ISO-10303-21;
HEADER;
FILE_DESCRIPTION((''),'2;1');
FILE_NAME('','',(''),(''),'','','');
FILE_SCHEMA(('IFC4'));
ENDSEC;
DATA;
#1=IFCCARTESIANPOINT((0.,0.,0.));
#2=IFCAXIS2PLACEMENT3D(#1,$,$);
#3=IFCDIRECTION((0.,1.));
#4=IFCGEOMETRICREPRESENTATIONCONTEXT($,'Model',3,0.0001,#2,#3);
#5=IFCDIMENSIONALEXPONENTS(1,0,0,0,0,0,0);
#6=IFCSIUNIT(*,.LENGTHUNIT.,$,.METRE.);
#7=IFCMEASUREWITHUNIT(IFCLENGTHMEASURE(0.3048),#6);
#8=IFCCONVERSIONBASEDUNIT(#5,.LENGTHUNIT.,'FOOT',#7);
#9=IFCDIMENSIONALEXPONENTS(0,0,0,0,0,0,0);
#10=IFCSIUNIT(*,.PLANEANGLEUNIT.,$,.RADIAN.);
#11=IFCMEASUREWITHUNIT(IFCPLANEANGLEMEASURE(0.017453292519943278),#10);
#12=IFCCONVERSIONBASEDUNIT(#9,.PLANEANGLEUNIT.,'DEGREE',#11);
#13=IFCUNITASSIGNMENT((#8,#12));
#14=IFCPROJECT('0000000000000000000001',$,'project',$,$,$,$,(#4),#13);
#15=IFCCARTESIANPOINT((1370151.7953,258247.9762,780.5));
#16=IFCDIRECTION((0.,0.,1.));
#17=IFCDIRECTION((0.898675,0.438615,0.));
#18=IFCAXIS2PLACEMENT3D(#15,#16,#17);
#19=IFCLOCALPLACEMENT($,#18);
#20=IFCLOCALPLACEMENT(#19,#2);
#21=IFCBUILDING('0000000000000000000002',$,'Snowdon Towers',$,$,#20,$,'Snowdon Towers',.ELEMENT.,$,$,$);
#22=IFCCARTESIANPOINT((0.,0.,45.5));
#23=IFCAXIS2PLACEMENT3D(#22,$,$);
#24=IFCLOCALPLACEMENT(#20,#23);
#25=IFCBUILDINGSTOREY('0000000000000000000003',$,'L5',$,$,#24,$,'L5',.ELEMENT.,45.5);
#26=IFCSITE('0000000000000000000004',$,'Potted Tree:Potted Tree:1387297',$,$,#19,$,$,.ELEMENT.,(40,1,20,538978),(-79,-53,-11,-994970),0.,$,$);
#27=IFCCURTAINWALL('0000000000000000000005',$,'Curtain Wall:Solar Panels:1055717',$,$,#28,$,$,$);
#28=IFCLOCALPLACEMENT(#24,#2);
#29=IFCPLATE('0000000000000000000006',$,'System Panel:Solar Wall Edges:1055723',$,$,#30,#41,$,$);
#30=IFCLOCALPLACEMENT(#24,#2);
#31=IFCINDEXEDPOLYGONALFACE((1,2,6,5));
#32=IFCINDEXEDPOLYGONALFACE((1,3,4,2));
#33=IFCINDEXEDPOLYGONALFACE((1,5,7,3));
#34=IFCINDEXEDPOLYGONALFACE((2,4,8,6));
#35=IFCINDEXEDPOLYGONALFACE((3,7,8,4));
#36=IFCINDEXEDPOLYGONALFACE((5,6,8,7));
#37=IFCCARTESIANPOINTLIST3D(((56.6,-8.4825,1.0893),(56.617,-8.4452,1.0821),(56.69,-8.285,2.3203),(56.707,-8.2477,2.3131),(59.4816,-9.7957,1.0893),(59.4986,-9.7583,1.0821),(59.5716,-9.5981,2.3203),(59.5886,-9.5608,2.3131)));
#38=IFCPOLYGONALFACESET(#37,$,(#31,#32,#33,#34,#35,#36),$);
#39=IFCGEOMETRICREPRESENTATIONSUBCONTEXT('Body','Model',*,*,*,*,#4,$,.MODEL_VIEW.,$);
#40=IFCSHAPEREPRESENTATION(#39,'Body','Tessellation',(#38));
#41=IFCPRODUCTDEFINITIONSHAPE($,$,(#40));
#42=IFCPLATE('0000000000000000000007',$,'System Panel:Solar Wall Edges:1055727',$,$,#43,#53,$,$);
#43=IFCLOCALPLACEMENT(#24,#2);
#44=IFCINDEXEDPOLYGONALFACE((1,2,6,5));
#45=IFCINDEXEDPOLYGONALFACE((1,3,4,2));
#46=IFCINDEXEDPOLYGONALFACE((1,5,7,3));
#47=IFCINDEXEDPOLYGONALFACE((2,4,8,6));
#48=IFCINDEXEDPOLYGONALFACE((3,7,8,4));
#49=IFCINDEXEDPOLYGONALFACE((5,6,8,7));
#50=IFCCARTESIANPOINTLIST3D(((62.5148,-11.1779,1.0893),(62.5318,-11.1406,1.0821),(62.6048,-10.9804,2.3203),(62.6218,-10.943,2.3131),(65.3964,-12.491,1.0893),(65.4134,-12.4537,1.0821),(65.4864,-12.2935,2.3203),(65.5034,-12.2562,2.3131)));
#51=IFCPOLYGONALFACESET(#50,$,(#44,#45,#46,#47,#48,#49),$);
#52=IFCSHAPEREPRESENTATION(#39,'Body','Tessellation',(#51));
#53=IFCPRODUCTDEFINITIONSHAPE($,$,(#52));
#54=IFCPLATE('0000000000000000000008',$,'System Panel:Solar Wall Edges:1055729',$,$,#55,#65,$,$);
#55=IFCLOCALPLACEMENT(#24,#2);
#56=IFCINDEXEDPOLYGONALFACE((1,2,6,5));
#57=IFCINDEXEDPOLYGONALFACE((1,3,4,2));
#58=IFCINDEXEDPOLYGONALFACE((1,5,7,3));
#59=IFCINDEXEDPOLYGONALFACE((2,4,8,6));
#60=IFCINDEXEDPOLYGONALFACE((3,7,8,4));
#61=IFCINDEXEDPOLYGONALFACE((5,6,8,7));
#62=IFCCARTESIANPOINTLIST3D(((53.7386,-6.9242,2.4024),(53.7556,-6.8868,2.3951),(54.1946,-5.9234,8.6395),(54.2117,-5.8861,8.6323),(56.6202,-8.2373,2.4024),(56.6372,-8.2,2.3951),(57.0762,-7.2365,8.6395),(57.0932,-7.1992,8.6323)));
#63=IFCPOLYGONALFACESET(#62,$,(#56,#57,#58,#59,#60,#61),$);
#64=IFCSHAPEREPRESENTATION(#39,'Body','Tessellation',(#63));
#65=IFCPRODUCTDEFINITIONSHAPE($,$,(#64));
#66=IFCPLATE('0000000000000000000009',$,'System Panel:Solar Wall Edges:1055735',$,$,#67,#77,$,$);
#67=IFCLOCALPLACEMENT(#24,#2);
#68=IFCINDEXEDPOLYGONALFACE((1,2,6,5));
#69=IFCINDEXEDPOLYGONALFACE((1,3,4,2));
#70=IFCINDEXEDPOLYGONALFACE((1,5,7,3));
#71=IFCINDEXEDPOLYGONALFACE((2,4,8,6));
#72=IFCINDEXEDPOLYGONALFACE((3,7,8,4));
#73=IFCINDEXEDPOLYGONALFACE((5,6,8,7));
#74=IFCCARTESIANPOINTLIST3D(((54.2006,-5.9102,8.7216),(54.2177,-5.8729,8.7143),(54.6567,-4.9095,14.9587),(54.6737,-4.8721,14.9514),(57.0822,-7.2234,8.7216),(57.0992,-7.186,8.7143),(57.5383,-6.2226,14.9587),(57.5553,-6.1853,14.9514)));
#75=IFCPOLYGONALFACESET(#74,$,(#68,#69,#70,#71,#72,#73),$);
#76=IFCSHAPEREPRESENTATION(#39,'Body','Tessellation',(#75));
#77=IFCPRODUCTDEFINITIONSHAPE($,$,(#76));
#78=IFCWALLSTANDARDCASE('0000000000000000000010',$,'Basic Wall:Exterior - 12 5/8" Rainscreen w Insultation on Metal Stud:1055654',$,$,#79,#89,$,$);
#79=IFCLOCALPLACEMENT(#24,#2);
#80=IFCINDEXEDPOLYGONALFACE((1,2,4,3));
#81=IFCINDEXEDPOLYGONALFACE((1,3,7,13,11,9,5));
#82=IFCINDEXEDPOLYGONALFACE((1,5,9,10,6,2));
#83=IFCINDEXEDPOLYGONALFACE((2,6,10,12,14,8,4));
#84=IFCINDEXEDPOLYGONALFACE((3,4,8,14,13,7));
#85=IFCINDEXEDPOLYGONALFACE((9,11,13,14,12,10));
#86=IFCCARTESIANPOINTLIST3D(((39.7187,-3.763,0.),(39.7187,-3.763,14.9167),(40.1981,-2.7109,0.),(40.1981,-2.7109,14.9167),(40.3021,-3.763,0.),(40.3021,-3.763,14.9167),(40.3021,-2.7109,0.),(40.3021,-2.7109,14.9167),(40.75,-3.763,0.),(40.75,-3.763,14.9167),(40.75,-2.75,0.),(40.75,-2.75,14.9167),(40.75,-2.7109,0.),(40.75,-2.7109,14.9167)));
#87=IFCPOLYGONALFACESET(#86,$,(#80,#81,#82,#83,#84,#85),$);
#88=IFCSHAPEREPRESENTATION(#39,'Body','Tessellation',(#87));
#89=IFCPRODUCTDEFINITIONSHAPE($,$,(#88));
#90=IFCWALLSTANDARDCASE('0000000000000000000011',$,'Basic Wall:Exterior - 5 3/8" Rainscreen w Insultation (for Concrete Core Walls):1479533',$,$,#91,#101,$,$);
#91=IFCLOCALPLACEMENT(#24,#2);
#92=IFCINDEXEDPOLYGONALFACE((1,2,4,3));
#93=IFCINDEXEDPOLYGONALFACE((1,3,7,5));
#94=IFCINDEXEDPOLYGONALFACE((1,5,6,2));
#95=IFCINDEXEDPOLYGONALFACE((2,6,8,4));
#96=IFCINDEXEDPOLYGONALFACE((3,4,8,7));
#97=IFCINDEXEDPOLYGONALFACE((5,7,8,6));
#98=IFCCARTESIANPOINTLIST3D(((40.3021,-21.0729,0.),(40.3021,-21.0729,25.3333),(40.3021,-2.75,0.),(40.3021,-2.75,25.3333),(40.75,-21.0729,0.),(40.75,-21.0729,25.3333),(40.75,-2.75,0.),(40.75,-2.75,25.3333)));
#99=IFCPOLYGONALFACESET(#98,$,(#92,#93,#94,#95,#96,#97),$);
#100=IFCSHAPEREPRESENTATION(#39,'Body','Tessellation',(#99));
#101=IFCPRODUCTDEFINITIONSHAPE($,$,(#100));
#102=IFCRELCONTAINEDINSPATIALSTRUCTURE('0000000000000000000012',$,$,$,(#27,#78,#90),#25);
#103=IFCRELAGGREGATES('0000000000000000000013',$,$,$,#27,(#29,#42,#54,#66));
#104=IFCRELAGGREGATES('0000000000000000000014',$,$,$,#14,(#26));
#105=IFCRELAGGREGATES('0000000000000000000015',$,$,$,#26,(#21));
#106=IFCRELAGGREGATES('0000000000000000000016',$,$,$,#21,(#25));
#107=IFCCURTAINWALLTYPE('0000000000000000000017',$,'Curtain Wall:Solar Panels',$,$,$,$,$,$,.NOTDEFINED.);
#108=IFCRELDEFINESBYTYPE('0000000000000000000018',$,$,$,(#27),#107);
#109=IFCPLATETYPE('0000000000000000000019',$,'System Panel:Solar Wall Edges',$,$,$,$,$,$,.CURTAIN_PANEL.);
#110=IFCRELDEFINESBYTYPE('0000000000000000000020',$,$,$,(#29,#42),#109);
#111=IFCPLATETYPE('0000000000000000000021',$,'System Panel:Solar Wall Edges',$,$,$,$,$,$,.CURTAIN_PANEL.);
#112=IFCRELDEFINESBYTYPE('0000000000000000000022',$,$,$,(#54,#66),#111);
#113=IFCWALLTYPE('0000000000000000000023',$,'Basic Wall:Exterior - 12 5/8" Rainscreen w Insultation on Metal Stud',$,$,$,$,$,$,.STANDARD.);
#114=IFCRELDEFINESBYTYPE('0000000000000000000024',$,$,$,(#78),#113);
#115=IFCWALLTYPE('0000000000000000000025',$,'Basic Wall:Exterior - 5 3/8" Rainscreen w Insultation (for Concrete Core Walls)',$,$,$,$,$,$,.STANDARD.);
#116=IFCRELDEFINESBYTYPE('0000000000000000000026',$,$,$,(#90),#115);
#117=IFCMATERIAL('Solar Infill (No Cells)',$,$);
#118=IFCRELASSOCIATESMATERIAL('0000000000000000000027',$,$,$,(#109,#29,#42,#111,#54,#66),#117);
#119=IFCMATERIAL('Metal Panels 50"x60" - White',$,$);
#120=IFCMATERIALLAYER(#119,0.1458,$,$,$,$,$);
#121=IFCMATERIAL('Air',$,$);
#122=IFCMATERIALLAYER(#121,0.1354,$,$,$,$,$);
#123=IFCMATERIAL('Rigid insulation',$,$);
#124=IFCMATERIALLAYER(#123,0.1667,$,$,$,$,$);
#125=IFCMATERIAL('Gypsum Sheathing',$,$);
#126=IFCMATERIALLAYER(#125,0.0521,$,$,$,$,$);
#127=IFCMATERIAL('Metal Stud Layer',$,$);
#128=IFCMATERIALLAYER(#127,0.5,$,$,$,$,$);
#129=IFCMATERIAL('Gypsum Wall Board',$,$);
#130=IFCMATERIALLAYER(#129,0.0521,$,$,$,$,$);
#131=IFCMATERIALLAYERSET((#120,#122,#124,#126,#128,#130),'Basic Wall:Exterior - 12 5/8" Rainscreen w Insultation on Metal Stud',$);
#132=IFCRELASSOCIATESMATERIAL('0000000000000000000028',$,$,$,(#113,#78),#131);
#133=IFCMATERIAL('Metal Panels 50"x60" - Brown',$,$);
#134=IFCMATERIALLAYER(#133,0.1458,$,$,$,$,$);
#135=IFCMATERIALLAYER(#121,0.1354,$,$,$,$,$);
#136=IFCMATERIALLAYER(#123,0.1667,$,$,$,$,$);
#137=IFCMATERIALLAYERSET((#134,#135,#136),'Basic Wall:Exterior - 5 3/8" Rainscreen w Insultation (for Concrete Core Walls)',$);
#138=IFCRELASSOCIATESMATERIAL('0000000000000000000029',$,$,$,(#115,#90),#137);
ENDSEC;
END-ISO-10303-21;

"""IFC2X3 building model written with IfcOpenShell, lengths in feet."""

from ifc_helpers import new_model, entity, si_unit, converted_unit, direction, frame, frame_2d, origin, place, context, subcontext, project, spatial, polyline, rectangle, outline, extrude, source, transform, mapped, material, layer, layer_set, layer_usage, type_object, type_shapes, element, aggregate, save


model = new_model("IFC2X3")

# Units and contexts
model_context = context("Model", 3, precision=0.0001, world=origin(), true_north=direction((0.0, 1.0)))
body_context = subcontext(model_context, "Body", "Model", "MODEL_VIEW")
ifc_project = project(units=[converted_unit("LENGTHUNIT", "FOOT", entity("IfcLengthMeasure", 0.3048), si_unit("LENGTHUNIT", "METRE"), dimensions=[1, 0, 0, 0, 0, 0, 0]), converted_unit("PLANEANGLEUNIT", "DEGREE", entity("IfcPlaneAngleMeasure", 0.017453292519943278), si_unit("PLANEANGLEUNIT", "RADIAN"), dimensions=[0, 0, 0, 0, 0, 0, 0])], contexts=[model_context])

# Site, building, storey
site_placement = place(None, frame((1370151.7953, 258247.9762, 780.5), z_axis=(0.0, 0.0, 1.0), x_axis=(0.898675, 0.438615, 0.0)))
site = spatial("IfcSite", under=ifc_project, at=site_placement, Name="Potted Tree:Potted Tree:1387297", CompositionType="ELEMENT", RefLatitude=(40, 1, 20, 538978), RefLongitude=(-79, -53, -11, -994970), RefElevation=0.0)
building_placement = place(site_placement, origin())
building = spatial("IfcBuilding", under=site, at=building_placement, Name="Snowdon Towers", LongName="Snowdon Towers", CompositionType="ELEMENT")
storey_placement = place(building_placement, frame((0.0, 0.0, 45.5)))
storey = spatial("IfcBuildingStorey", under=building, at=storey_placement, Name="L5", LongName="L5", CompositionType="ELEMENT", Elevation=45.5)

# Curtain wall, plates
curtain_wall_type = type_object("IfcCurtainWallType", Name="Curtain Wall:Solar Panels", PredefinedType="NOTDEFINED")
curtain_wall_placement = place(storey_placement, frame((0.0, 0.0, -45.5)))
curtain_wall = element("IfcCurtainWall", 1, at=curtain_wall_placement, inside=storey, type_object=curtain_wall_type, Name="Curtain Wall:Solar Panels:1055717")
ifc_material_1 = material(Name="Solar Infill (No Cells)")
plate_type_1 = type_object("IfcPlateType", Name="System Panel:Solar Wall Edges", PredefinedType="CURTAIN_PANEL", material=ifc_material_1)
shared_shape_1 = source(origin(), body_context, "Body", "SweptSolid", [
    extrude(rectangle(XDim=0.0417, YDim=3.1667, at=frame_2d((0.0, 0.0), x_axis=(1.0, 0.0))), frame((0.0, -0.0208, 0.0), z_axis=(0.0, 0.0, 1.0), x_axis=(0.0, 1.0, 0.0)), (0.0, 0.0, 1.0), 1.25),
])
type_shapes(plate_type_1, [shared_shape_1])
plate_1_placement = place(curtain_wall_placement, frame((58.0578, -9.1018, 46.5821), z_axis=(0.072007, 0.158015, 0.984808), x_axis=(0.909972, -0.414671, 0.0)))
plate_1 = element("IfcPlate", 2, at=plate_1_placement, type_object=plate_type_1, material=ifc_material_1, Name="System Panel:Solar Wall Edges:1055723", context=body_context, shape_type="MappedRepresentation", body=[
    mapped(shared_shape_1, transform((0.0, 0.0, 0.0), scale=1.0)),
])
plate_2_placement = place(curtain_wall_placement, frame((63.9726, -11.7971, 46.5821), z_axis=(0.072007, 0.158015, 0.984808), x_axis=(0.909972, -0.414671, 0.0)))
plate_2 = element("IfcPlate", 3, at=plate_2_placement, type_object=plate_type_1, material=ifc_material_1, Name="System Panel:Solar Wall Edges:1055727", context=body_context, shape_type="MappedRepresentation", body=[
    mapped(shared_shape_1, transform((0.0, 0.0, 0.0), scale=1.0)),
])
plate_type_2 = type_object("IfcPlateType", Name="System Panel:Solar Wall Edges", PredefinedType="CURTAIN_PANEL", material=ifc_material_1)
shared_shape_2 = source(origin(), body_context, "Body", "SweptSolid", [
    extrude(rectangle(XDim=0.0417, YDim=3.1667, at=frame_2d((0.0, 0.0), x_axis=(1.0, 0.0))), frame((0.0, -0.0208, 0.0), z_axis=(0.0, 0.0, 1.0), x_axis=(0.0, 1.0, 0.0)), (0.0, 0.0, 1.0), 6.3333),
])
type_shapes(plate_type_2, [shared_shape_2])
plate_3_placement = place(curtain_wall_placement, frame((55.1964, -7.5434, 47.8951), z_axis=(0.072007, 0.158015, 0.984808), x_axis=(0.909972, -0.414671, 0.0)))
plate_3 = element("IfcPlate", 4, at=plate_3_placement, type_object=plate_type_2, material=ifc_material_1, Name="System Panel:Solar Wall Edges:1055729", context=body_context, shape_type="MappedRepresentation", body=[
    mapped(shared_shape_2, transform((0.0, 0.0, 0.0), scale=1.0)),
])
plate_4_placement = place(curtain_wall_placement, frame((55.6585, -6.5295, 54.2143), z_axis=(0.072007, 0.158015, 0.984808), x_axis=(0.909972, -0.414671, 0.0)))
plate_4 = element("IfcPlate", 5, at=plate_4_placement, type_object=plate_type_2, material=ifc_material_1, Name="System Panel:Solar Wall Edges:1055735", context=body_context, shape_type="MappedRepresentation", body=[
    mapped(shared_shape_2, transform((0.0, 0.0, 0.0), scale=1.0)),
])
aggregate(curtain_wall, [plate_1, plate_2, plate_3, plate_4])

# Walls
ifc_material_2 = material(Name="Metal Panels 50\"x60\" - White")
ifc_layer_1 = layer(ifc_material_2, 0.1458)
ifc_material_3 = material(Name="Air")
ifc_layer_2 = layer(ifc_material_3, 0.1354)
ifc_material_4 = material(Name="Rigid insulation")
ifc_layer_3 = layer(ifc_material_4, 0.1667)
ifc_material_5 = material(Name="Gypsum Sheathing")
ifc_layer_4 = layer(ifc_material_5, 0.0521)
ifc_material_6 = material(Name="Metal Stud Layer")
ifc_layer_5 = layer(ifc_material_6, 0.5)
ifc_material_7 = material(Name="Gypsum Wall Board")
ifc_layer_6 = layer(ifc_material_7, 0.0521)
ifc_layer_set_1 = layer_set([ifc_layer_1, ifc_layer_2, ifc_layer_3, ifc_layer_4, ifc_layer_5, ifc_layer_6], Name="Basic Wall:Exterior - 12 5/8\" Rainscreen w Insultation on Metal Stud")
ifc_layer_usage_1 = layer_usage(ifc_layer_set_1, "AXIS2", "NEGATIVE", 0.526)
wall_type_1 = type_object("IfcWallType", Name="Basic Wall:Exterior - 12 5/8\" Rainscreen w Insultation on Metal Stud", PredefinedType="STANDARD", material=ifc_layer_set_1)
wall_1_placement = place(storey_placement, frame((40.75, -3.237, 0.0), z_axis=(0.0, 0.0, 1.0), x_axis=(-1.0, 0.0, 0.0)))
element("IfcWallStandardCase", 6, at=wall_1_placement, inside=storey, type_object=wall_type_1, material=ifc_layer_usage_1, Name="Basic Wall:Exterior - 12 5/8\" Rainscreen w Insultation on Metal Stud:1055654", context=body_context, shape_type="SweptSolid", body=[
    extrude(outline(polyline([(0.0, -0.526), (0.4479, -0.526), (0.5519, -0.526), (1.0313, 0.526), (0.4479, 0.526), (0.0, 0.526), (0.0, -0.487), (0.0, -0.526)])), origin(), (0.0, 0.0, 1.0), 14.9167),
])
ifc_material_8 = material(Name="Metal Panels 50\"x60\" - Brown")
ifc_layer_7 = layer(ifc_material_8, 0.1458)
ifc_layer_8 = layer(ifc_material_3, 0.1354)
ifc_layer_9 = layer(ifc_material_4, 0.1667)
ifc_layer_set_2 = layer_set([ifc_layer_7, ifc_layer_8, ifc_layer_9], Name="Basic Wall:Exterior - 5 3/8\" Rainscreen w Insultation (for Concrete Core Walls)")
ifc_layer_usage_2 = layer_usage(ifc_layer_set_2, "AXIS2", "POSITIVE", -0.224)
wall_type_2 = type_object("IfcWallType", Name="Basic Wall:Exterior - 5 3/8\" Rainscreen w Insultation (for Concrete Core Walls)", PredefinedType="STANDARD", material=ifc_layer_set_2)
wall_2_placement = place(storey_placement, frame((40.526, -2.75, 0.0), z_axis=(0.0, 0.0, 1.0), x_axis=(0.0, -1.0, 0.0)))
element("IfcWallStandardCase", 7, at=wall_2_placement, inside=storey, type_object=wall_type_2, material=ifc_layer_usage_2, Name="Basic Wall:Exterior - 5 3/8\" Rainscreen w Insultation (for Concrete Core Walls):1479533", context=body_context, shape_type="SweptSolid", body=[
    extrude(rectangle(XDim=18.3229, YDim=0.4479, at=frame_2d((9.1615, 0.0), x_axis=(-1.0, 0.0))), origin(), (0.0, 0.0, 1.0), 25.3333),
])

save(model, "model.ifc")
